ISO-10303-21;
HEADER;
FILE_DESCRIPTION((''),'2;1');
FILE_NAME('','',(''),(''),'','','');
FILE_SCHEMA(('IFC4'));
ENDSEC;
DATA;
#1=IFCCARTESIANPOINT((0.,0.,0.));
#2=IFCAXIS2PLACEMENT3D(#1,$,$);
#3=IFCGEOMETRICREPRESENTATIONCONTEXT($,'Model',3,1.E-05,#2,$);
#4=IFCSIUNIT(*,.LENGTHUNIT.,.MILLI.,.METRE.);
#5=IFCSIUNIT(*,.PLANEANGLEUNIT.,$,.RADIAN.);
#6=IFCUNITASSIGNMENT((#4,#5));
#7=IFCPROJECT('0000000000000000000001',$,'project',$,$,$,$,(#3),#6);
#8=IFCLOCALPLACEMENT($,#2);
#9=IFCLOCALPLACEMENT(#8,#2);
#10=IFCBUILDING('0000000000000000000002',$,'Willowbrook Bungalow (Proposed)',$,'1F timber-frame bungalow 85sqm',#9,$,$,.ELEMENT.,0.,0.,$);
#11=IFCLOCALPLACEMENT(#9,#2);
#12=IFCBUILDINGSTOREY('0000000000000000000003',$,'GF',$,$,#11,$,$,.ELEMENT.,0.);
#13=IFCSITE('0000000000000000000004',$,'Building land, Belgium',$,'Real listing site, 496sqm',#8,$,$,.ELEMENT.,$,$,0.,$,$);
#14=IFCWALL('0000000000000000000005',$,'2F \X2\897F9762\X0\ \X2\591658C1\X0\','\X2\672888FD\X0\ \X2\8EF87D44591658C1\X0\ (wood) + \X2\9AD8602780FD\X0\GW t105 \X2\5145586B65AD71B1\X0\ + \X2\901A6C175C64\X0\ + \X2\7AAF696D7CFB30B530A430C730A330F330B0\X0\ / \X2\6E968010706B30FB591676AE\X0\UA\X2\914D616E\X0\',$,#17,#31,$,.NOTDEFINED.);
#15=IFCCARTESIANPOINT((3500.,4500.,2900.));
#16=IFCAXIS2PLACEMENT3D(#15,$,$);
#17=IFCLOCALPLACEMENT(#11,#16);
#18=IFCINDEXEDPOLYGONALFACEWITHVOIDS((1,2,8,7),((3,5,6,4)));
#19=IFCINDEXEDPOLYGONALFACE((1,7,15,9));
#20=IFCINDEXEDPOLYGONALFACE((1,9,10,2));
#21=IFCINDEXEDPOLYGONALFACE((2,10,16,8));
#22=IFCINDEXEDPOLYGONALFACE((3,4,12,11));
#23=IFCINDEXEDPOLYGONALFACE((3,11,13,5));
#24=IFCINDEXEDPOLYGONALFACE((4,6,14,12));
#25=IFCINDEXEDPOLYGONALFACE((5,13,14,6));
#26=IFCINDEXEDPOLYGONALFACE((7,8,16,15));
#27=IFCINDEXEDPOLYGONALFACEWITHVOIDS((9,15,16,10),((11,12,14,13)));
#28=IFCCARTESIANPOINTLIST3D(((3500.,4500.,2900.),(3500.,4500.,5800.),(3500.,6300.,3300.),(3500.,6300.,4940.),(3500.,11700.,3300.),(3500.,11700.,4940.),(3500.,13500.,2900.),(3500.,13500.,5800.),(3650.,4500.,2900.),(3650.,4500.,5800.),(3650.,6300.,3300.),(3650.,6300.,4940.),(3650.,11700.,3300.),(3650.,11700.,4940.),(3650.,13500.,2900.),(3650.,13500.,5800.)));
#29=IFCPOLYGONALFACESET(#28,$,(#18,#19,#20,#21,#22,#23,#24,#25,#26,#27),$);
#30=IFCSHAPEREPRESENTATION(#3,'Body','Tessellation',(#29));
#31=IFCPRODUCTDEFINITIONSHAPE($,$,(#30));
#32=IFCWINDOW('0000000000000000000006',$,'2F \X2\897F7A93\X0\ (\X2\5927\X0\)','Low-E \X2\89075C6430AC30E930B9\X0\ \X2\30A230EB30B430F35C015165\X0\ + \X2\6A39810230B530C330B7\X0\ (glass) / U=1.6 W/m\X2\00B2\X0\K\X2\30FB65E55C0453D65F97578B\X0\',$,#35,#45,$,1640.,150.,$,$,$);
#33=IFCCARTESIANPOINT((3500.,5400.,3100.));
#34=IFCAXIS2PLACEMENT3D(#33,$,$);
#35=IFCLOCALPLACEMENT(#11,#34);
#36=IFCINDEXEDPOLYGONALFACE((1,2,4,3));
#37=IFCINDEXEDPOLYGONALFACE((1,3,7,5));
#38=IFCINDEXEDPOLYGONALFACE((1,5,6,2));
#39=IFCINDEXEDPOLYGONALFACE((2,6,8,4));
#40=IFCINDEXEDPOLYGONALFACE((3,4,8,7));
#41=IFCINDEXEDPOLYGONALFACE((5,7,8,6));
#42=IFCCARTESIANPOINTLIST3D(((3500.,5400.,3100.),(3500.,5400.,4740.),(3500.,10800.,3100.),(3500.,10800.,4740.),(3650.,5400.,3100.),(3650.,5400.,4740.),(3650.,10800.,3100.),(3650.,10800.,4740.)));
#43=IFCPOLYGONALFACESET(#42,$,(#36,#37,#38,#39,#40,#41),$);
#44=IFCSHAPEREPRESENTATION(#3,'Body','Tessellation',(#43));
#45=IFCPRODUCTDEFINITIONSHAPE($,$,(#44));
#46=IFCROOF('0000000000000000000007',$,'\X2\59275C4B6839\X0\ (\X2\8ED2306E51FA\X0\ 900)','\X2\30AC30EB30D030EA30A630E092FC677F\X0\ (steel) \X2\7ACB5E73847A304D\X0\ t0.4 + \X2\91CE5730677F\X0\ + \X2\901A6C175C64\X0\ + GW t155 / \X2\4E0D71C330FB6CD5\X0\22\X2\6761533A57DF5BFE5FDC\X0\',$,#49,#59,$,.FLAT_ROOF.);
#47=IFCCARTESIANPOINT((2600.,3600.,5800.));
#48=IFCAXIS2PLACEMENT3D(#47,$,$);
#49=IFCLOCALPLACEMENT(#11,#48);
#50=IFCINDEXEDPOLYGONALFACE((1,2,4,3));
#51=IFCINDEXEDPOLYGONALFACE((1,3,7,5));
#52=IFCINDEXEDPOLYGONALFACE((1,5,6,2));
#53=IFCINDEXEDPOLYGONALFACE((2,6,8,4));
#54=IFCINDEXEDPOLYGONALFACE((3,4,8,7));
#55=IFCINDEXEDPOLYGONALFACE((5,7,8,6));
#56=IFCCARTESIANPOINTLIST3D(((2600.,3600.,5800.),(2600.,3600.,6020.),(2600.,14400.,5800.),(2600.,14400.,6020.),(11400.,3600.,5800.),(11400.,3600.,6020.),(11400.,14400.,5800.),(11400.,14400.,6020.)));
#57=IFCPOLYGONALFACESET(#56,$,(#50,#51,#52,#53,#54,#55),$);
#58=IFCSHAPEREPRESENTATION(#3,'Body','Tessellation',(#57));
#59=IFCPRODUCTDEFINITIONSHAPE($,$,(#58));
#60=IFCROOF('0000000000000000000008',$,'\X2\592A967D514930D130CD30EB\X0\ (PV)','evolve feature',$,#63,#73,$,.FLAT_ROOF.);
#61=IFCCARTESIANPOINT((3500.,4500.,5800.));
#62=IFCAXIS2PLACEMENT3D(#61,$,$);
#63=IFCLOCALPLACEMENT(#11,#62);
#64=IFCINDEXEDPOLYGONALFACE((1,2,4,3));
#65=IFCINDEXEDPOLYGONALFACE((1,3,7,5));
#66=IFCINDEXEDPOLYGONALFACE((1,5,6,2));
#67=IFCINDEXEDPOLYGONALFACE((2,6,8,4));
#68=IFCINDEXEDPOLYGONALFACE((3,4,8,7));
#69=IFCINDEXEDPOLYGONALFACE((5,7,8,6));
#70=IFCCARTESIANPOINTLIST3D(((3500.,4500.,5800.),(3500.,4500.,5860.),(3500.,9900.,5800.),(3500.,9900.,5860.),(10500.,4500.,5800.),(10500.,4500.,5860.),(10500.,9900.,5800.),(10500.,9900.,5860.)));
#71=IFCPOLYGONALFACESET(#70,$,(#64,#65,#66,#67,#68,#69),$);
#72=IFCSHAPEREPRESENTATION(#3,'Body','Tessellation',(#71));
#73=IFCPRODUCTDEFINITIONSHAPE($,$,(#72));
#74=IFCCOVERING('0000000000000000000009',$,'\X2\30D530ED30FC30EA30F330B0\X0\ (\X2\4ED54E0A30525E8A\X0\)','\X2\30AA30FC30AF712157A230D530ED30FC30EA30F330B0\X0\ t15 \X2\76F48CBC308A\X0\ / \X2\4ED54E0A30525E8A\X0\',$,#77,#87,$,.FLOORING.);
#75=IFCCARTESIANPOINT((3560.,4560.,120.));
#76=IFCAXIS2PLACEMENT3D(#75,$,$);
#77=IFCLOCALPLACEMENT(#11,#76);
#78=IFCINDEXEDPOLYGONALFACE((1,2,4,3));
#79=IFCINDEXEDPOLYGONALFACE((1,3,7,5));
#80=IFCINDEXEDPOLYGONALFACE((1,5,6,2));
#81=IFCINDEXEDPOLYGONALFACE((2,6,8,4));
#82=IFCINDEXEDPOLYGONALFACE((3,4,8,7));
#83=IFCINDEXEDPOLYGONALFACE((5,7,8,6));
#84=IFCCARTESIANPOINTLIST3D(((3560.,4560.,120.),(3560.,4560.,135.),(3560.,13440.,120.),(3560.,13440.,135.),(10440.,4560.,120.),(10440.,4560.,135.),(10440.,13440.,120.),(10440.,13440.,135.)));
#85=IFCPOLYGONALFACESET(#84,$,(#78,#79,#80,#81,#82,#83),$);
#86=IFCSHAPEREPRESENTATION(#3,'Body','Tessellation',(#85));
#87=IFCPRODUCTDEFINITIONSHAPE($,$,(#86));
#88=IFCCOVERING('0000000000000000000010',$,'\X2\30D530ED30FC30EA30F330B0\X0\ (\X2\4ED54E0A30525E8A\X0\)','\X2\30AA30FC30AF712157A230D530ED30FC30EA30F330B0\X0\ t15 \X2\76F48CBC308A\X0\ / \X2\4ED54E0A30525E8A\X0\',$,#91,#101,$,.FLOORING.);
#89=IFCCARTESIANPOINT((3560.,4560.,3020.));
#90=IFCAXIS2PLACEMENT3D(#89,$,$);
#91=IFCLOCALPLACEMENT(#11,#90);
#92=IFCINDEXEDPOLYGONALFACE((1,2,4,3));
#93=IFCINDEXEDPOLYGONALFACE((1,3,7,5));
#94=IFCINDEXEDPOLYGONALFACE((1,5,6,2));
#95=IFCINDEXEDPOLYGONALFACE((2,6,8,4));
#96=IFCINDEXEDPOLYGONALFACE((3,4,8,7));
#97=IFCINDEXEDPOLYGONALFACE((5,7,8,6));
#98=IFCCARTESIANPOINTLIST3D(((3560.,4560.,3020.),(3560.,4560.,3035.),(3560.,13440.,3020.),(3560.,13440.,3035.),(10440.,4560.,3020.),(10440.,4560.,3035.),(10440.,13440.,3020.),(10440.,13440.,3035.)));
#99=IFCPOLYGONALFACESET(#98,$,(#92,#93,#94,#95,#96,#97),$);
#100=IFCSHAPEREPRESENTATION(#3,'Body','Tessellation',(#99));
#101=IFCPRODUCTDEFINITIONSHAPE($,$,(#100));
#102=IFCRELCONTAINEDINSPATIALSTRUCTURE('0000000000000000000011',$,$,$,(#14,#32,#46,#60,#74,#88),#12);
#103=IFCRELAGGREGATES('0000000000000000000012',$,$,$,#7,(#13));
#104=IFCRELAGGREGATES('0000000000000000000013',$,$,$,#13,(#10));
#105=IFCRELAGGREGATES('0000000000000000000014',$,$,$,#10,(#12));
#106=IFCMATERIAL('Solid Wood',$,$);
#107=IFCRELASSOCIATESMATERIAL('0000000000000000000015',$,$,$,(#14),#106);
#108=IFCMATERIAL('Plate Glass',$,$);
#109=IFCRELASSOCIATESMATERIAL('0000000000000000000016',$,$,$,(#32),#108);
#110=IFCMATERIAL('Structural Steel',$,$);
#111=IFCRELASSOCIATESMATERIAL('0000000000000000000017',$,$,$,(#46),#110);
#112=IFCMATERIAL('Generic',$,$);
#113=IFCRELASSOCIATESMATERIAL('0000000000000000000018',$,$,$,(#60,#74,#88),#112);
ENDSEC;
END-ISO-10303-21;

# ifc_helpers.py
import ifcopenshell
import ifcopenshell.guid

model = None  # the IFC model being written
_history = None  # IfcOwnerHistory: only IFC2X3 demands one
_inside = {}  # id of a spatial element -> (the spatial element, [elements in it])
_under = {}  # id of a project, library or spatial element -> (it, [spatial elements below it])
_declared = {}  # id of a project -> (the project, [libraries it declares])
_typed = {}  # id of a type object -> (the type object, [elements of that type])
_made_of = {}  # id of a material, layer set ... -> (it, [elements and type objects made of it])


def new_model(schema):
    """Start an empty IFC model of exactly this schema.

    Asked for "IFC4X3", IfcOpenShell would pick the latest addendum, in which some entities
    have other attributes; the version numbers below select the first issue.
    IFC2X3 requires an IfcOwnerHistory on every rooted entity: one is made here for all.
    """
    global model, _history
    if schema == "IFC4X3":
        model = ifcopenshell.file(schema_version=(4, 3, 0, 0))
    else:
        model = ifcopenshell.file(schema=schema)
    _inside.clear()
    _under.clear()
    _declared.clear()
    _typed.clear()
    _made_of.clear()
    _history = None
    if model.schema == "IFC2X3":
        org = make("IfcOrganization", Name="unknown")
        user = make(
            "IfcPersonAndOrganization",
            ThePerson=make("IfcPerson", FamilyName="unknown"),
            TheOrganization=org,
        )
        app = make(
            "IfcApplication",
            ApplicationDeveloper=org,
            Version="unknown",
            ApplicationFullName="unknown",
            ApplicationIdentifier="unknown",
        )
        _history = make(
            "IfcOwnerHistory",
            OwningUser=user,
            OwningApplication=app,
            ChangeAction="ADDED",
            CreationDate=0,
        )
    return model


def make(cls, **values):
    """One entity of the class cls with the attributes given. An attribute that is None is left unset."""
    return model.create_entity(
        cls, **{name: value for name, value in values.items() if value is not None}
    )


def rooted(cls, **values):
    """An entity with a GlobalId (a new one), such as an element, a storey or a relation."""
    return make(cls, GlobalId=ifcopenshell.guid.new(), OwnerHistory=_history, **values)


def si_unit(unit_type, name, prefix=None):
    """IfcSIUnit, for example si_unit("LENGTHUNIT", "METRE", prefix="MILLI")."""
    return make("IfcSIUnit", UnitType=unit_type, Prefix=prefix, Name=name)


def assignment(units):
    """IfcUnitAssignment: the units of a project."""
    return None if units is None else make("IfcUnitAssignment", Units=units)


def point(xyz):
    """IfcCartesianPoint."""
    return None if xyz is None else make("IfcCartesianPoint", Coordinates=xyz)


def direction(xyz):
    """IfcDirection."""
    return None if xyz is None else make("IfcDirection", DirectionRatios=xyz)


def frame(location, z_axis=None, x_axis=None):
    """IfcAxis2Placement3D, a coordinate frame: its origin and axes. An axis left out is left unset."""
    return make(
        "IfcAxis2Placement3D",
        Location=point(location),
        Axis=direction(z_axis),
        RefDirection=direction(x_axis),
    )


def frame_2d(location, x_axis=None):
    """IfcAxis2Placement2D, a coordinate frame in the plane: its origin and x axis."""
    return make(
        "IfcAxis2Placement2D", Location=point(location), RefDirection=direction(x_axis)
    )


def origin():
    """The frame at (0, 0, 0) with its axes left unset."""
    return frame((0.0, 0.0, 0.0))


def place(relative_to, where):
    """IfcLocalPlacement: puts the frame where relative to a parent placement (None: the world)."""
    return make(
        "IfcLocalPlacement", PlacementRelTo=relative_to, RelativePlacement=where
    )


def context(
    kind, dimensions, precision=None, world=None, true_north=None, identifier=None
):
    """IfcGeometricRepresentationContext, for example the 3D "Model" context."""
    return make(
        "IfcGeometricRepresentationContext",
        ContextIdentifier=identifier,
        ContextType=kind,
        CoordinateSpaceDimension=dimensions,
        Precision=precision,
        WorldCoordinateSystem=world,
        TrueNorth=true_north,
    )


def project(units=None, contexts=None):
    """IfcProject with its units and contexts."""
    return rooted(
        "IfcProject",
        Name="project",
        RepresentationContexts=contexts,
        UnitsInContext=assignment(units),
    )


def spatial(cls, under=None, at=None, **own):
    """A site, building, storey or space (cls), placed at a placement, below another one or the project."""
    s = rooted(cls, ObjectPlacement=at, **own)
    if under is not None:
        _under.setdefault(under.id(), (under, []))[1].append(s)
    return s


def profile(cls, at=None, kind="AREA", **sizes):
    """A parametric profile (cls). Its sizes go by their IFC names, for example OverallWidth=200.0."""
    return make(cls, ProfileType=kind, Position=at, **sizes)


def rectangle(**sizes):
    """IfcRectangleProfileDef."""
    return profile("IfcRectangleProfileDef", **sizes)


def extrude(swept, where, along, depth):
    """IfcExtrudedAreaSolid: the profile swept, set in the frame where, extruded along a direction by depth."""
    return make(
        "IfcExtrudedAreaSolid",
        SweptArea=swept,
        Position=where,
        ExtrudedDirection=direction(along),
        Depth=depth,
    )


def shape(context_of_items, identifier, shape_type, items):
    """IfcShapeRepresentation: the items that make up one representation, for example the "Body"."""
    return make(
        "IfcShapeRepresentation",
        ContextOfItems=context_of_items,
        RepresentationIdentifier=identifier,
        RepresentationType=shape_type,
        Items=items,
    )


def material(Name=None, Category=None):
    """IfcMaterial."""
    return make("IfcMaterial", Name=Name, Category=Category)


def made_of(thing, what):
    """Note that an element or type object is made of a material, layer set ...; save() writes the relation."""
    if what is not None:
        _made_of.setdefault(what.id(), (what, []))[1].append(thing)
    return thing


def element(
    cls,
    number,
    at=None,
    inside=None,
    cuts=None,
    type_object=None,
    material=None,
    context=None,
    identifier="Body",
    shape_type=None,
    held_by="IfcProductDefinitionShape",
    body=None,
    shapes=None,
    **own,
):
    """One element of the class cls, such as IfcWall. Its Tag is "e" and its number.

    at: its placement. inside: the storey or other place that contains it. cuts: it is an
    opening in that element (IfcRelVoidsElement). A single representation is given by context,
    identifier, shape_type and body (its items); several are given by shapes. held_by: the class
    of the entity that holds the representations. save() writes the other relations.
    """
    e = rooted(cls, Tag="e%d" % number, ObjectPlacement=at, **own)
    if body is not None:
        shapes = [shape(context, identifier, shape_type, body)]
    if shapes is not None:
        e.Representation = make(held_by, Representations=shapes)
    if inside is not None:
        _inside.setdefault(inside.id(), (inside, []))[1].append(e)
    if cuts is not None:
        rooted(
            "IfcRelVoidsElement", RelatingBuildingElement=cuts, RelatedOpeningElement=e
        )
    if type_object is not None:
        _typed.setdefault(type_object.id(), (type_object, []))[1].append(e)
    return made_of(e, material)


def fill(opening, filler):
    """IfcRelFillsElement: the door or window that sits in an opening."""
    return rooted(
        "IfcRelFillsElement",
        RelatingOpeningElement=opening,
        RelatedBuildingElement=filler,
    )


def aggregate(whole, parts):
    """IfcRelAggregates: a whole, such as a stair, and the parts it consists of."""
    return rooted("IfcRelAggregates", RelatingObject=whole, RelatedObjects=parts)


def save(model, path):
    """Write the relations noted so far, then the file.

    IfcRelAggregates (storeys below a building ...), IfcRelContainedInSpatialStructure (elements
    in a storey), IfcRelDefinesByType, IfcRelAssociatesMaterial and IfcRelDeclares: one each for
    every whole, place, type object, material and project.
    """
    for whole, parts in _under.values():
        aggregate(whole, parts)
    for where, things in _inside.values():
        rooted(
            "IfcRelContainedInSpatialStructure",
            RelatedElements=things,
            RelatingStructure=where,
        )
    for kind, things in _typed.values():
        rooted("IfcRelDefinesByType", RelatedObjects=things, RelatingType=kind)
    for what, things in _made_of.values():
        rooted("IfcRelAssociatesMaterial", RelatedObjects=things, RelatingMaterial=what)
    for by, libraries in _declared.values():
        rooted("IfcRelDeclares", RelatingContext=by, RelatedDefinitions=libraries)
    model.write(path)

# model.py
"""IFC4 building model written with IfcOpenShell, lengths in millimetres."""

from ifc_helpers import new_model, si_unit, frame, frame_2d, origin, place, context, project, spatial, rectangle, extrude, material, element, fill, save


model = new_model("IFC4")

# Units and contexts
model_context = context("Model", 3, precision=1e-05, world=origin())
ifc_project = project(units=[si_unit("LENGTHUNIT", "METRE", prefix="MILLI"), si_unit("PLANEANGLEUNIT", "RADIAN")], contexts=[model_context])

# Site, building, storey
site_placement = place(None, origin())
site = spatial("IfcSite", under=ifc_project, at=site_placement, Name="Building land, Belgium", ObjectType="Real listing site, 496sqm", CompositionType="ELEMENT", RefElevation=0.0)
building_placement = place(site_placement, origin())
building = spatial("IfcBuilding", under=site, at=building_placement, Name="Willowbrook Bungalow (Proposed)", ObjectType="1F timber-frame bungalow 85sqm", CompositionType="ELEMENT", ElevationOfRefHeight=0.0, ElevationOfTerrain=0.0)
storey_placement = place(building_placement, origin())
storey = spatial("IfcBuildingStorey", under=building, at=storey_placement, Name="GF", CompositionType="ELEMENT", Elevation=0.0)

# Shared definitions
ifc_material_1 = material(Name="Solid Wood")
ifc_material_2 = material(Name="Generic")

# Shared definitions
ifc_material_3 = material(Name="Plate Glass")

# Wall, opening, window
wall_1_placement = place(storey_placement, frame((3500.0, 4500.0, 2900.0)))
wall_1 = element("IfcWall", 1, at=wall_1_placement, inside=storey, material=ifc_material_1, Name="2F 西面 外壁", Description="木製 軸組外壁 (wood) + 高性能GW t105 充填断熱 + 通気層 + 窯業系サイディング / 準耐火・外皮UA配慮", PredefinedType="NOTDEFINED", context=model_context, shape_type="SweptSolid", body=[
    extrude(rectangle(XDim=150.0, YDim=9000.0, at=frame_2d((75.0, 4500.0))), frame((3500.0, 4500.0, 2900.0)), (0.0, 0.0, 1.0), 2900.0),
])
opening_1_placement = place(storey_placement, frame((3500.0, 5400.0, 3100.0)))
opening_1 = element("IfcOpeningElement", 2, at=opening_1_placement, cuts=wall_1, PredefinedType="NOTDEFINED", context=model_context, shape_type="SweptSolid", body=[
    extrude(rectangle(XDim=150.0, YDim=5400.0, at=frame_2d((75.0, 2700.0))), frame((3500.0, 5400.0, 3100.0)), (0.0, 0.0, 1.0), 1640.0),
])
window_1_placement = place(storey_placement, frame((3500.0, 5400.0, 3100.0)))
window_1 = element("IfcWindow", 3, at=window_1_placement, inside=storey, material=ifc_material_3, Name="2F 西窓 (大)", Description="Low-E 複層ガラス アルゴン封入 + 樹脂サッシ (glass) / U=1.6 W/m²K・日射取得型", OverallHeight=1640.0, OverallWidth=150.0, context=model_context, shape_type="SweptSolid", body=[
    extrude(rectangle(XDim=150.0, YDim=5400.0, at=frame_2d((75.0, 2700.0))), frame((3500.0, 5400.0, 3100.0)), (0.0, 0.0, 1.0), 1640.0),
])
fill(opening_1, window_1)

# Roofs
ifc_material_4 = material(Name="Structural Steel")
roof_1_placement = place(storey_placement, frame((2600.0, 3600.0, 5800.0)))
element("IfcRoof", 4, at=roof_1_placement, inside=storey, material=ifc_material_4, Name="大屋根 (軒の出 900)", Description="ガルバリウム鋼板 (steel) 立平葺き t0.4 + 野地板 + 通気層 + GW t155 / 不燃・法22条区域対応", PredefinedType="FLAT_ROOF", context=model_context, shape_type="SweptSolid", body=[
    extrude(rectangle(XDim=8800.0, YDim=10800.0, at=frame_2d((4400.0, 5400.0))), frame((2600.0, 3600.0, 5800.0)), (0.0, 0.0, 1.0), 220.0),
])
roof_2_placement = place(storey_placement, frame((3500.0, 4500.0, 5800.0)))
element("IfcRoof", 5, at=roof_2_placement, inside=storey, material=ifc_material_2, Name="太陽光パネル (PV)", Description="evolve feature", PredefinedType="FLAT_ROOF", context=model_context, shape_type="SweptSolid", body=[
    extrude(rectangle(XDim=7000.0, YDim=5400.0, at=frame_2d((3500.0, 2700.0))), frame((3500.0, 4500.0, 5800.0)), (0.0, 0.0, 1.0), 60.0),
])

# Coverings
covering_1_placement = place(storey_placement, frame((3560.0, 4560.0, 120.0)))
element("IfcCovering", 6, at=covering_1_placement, inside=storey, material=ifc_material_2, Name="フローリング (仕上げ床)", Description="オーク無垢フローリング t15 直貼り / 仕上げ床", PredefinedType="FLOORING", context=model_context, shape_type="SweptSolid", body=[
    extrude(rectangle(XDim=6880.0, YDim=8880.0, at=frame_2d((3440.0, 4440.0))), frame((3560.0, 4560.0, 120.0)), (0.0, 0.0, 1.0), 15.0),
])
covering_2_placement = place(storey_placement, frame((3560.0, 4560.0, 3020.0)))
element("IfcCovering", 7, at=covering_2_placement, inside=storey, material=ifc_material_2, Name="フローリング (仕上げ床)", Description="オーク無垢フローリング t15 直貼り / 仕上げ床", PredefinedType="FLOORING", context=model_context, shape_type="SweptSolid", body=[
    extrude(rectangle(XDim=6880.0, YDim=8880.0, at=frame_2d((3440.0, 4440.0))), frame((3560.0, 4560.0, 3020.0)), (0.0, 0.0, 1.0), 15.0),
])

save(model, "model.ifc")
